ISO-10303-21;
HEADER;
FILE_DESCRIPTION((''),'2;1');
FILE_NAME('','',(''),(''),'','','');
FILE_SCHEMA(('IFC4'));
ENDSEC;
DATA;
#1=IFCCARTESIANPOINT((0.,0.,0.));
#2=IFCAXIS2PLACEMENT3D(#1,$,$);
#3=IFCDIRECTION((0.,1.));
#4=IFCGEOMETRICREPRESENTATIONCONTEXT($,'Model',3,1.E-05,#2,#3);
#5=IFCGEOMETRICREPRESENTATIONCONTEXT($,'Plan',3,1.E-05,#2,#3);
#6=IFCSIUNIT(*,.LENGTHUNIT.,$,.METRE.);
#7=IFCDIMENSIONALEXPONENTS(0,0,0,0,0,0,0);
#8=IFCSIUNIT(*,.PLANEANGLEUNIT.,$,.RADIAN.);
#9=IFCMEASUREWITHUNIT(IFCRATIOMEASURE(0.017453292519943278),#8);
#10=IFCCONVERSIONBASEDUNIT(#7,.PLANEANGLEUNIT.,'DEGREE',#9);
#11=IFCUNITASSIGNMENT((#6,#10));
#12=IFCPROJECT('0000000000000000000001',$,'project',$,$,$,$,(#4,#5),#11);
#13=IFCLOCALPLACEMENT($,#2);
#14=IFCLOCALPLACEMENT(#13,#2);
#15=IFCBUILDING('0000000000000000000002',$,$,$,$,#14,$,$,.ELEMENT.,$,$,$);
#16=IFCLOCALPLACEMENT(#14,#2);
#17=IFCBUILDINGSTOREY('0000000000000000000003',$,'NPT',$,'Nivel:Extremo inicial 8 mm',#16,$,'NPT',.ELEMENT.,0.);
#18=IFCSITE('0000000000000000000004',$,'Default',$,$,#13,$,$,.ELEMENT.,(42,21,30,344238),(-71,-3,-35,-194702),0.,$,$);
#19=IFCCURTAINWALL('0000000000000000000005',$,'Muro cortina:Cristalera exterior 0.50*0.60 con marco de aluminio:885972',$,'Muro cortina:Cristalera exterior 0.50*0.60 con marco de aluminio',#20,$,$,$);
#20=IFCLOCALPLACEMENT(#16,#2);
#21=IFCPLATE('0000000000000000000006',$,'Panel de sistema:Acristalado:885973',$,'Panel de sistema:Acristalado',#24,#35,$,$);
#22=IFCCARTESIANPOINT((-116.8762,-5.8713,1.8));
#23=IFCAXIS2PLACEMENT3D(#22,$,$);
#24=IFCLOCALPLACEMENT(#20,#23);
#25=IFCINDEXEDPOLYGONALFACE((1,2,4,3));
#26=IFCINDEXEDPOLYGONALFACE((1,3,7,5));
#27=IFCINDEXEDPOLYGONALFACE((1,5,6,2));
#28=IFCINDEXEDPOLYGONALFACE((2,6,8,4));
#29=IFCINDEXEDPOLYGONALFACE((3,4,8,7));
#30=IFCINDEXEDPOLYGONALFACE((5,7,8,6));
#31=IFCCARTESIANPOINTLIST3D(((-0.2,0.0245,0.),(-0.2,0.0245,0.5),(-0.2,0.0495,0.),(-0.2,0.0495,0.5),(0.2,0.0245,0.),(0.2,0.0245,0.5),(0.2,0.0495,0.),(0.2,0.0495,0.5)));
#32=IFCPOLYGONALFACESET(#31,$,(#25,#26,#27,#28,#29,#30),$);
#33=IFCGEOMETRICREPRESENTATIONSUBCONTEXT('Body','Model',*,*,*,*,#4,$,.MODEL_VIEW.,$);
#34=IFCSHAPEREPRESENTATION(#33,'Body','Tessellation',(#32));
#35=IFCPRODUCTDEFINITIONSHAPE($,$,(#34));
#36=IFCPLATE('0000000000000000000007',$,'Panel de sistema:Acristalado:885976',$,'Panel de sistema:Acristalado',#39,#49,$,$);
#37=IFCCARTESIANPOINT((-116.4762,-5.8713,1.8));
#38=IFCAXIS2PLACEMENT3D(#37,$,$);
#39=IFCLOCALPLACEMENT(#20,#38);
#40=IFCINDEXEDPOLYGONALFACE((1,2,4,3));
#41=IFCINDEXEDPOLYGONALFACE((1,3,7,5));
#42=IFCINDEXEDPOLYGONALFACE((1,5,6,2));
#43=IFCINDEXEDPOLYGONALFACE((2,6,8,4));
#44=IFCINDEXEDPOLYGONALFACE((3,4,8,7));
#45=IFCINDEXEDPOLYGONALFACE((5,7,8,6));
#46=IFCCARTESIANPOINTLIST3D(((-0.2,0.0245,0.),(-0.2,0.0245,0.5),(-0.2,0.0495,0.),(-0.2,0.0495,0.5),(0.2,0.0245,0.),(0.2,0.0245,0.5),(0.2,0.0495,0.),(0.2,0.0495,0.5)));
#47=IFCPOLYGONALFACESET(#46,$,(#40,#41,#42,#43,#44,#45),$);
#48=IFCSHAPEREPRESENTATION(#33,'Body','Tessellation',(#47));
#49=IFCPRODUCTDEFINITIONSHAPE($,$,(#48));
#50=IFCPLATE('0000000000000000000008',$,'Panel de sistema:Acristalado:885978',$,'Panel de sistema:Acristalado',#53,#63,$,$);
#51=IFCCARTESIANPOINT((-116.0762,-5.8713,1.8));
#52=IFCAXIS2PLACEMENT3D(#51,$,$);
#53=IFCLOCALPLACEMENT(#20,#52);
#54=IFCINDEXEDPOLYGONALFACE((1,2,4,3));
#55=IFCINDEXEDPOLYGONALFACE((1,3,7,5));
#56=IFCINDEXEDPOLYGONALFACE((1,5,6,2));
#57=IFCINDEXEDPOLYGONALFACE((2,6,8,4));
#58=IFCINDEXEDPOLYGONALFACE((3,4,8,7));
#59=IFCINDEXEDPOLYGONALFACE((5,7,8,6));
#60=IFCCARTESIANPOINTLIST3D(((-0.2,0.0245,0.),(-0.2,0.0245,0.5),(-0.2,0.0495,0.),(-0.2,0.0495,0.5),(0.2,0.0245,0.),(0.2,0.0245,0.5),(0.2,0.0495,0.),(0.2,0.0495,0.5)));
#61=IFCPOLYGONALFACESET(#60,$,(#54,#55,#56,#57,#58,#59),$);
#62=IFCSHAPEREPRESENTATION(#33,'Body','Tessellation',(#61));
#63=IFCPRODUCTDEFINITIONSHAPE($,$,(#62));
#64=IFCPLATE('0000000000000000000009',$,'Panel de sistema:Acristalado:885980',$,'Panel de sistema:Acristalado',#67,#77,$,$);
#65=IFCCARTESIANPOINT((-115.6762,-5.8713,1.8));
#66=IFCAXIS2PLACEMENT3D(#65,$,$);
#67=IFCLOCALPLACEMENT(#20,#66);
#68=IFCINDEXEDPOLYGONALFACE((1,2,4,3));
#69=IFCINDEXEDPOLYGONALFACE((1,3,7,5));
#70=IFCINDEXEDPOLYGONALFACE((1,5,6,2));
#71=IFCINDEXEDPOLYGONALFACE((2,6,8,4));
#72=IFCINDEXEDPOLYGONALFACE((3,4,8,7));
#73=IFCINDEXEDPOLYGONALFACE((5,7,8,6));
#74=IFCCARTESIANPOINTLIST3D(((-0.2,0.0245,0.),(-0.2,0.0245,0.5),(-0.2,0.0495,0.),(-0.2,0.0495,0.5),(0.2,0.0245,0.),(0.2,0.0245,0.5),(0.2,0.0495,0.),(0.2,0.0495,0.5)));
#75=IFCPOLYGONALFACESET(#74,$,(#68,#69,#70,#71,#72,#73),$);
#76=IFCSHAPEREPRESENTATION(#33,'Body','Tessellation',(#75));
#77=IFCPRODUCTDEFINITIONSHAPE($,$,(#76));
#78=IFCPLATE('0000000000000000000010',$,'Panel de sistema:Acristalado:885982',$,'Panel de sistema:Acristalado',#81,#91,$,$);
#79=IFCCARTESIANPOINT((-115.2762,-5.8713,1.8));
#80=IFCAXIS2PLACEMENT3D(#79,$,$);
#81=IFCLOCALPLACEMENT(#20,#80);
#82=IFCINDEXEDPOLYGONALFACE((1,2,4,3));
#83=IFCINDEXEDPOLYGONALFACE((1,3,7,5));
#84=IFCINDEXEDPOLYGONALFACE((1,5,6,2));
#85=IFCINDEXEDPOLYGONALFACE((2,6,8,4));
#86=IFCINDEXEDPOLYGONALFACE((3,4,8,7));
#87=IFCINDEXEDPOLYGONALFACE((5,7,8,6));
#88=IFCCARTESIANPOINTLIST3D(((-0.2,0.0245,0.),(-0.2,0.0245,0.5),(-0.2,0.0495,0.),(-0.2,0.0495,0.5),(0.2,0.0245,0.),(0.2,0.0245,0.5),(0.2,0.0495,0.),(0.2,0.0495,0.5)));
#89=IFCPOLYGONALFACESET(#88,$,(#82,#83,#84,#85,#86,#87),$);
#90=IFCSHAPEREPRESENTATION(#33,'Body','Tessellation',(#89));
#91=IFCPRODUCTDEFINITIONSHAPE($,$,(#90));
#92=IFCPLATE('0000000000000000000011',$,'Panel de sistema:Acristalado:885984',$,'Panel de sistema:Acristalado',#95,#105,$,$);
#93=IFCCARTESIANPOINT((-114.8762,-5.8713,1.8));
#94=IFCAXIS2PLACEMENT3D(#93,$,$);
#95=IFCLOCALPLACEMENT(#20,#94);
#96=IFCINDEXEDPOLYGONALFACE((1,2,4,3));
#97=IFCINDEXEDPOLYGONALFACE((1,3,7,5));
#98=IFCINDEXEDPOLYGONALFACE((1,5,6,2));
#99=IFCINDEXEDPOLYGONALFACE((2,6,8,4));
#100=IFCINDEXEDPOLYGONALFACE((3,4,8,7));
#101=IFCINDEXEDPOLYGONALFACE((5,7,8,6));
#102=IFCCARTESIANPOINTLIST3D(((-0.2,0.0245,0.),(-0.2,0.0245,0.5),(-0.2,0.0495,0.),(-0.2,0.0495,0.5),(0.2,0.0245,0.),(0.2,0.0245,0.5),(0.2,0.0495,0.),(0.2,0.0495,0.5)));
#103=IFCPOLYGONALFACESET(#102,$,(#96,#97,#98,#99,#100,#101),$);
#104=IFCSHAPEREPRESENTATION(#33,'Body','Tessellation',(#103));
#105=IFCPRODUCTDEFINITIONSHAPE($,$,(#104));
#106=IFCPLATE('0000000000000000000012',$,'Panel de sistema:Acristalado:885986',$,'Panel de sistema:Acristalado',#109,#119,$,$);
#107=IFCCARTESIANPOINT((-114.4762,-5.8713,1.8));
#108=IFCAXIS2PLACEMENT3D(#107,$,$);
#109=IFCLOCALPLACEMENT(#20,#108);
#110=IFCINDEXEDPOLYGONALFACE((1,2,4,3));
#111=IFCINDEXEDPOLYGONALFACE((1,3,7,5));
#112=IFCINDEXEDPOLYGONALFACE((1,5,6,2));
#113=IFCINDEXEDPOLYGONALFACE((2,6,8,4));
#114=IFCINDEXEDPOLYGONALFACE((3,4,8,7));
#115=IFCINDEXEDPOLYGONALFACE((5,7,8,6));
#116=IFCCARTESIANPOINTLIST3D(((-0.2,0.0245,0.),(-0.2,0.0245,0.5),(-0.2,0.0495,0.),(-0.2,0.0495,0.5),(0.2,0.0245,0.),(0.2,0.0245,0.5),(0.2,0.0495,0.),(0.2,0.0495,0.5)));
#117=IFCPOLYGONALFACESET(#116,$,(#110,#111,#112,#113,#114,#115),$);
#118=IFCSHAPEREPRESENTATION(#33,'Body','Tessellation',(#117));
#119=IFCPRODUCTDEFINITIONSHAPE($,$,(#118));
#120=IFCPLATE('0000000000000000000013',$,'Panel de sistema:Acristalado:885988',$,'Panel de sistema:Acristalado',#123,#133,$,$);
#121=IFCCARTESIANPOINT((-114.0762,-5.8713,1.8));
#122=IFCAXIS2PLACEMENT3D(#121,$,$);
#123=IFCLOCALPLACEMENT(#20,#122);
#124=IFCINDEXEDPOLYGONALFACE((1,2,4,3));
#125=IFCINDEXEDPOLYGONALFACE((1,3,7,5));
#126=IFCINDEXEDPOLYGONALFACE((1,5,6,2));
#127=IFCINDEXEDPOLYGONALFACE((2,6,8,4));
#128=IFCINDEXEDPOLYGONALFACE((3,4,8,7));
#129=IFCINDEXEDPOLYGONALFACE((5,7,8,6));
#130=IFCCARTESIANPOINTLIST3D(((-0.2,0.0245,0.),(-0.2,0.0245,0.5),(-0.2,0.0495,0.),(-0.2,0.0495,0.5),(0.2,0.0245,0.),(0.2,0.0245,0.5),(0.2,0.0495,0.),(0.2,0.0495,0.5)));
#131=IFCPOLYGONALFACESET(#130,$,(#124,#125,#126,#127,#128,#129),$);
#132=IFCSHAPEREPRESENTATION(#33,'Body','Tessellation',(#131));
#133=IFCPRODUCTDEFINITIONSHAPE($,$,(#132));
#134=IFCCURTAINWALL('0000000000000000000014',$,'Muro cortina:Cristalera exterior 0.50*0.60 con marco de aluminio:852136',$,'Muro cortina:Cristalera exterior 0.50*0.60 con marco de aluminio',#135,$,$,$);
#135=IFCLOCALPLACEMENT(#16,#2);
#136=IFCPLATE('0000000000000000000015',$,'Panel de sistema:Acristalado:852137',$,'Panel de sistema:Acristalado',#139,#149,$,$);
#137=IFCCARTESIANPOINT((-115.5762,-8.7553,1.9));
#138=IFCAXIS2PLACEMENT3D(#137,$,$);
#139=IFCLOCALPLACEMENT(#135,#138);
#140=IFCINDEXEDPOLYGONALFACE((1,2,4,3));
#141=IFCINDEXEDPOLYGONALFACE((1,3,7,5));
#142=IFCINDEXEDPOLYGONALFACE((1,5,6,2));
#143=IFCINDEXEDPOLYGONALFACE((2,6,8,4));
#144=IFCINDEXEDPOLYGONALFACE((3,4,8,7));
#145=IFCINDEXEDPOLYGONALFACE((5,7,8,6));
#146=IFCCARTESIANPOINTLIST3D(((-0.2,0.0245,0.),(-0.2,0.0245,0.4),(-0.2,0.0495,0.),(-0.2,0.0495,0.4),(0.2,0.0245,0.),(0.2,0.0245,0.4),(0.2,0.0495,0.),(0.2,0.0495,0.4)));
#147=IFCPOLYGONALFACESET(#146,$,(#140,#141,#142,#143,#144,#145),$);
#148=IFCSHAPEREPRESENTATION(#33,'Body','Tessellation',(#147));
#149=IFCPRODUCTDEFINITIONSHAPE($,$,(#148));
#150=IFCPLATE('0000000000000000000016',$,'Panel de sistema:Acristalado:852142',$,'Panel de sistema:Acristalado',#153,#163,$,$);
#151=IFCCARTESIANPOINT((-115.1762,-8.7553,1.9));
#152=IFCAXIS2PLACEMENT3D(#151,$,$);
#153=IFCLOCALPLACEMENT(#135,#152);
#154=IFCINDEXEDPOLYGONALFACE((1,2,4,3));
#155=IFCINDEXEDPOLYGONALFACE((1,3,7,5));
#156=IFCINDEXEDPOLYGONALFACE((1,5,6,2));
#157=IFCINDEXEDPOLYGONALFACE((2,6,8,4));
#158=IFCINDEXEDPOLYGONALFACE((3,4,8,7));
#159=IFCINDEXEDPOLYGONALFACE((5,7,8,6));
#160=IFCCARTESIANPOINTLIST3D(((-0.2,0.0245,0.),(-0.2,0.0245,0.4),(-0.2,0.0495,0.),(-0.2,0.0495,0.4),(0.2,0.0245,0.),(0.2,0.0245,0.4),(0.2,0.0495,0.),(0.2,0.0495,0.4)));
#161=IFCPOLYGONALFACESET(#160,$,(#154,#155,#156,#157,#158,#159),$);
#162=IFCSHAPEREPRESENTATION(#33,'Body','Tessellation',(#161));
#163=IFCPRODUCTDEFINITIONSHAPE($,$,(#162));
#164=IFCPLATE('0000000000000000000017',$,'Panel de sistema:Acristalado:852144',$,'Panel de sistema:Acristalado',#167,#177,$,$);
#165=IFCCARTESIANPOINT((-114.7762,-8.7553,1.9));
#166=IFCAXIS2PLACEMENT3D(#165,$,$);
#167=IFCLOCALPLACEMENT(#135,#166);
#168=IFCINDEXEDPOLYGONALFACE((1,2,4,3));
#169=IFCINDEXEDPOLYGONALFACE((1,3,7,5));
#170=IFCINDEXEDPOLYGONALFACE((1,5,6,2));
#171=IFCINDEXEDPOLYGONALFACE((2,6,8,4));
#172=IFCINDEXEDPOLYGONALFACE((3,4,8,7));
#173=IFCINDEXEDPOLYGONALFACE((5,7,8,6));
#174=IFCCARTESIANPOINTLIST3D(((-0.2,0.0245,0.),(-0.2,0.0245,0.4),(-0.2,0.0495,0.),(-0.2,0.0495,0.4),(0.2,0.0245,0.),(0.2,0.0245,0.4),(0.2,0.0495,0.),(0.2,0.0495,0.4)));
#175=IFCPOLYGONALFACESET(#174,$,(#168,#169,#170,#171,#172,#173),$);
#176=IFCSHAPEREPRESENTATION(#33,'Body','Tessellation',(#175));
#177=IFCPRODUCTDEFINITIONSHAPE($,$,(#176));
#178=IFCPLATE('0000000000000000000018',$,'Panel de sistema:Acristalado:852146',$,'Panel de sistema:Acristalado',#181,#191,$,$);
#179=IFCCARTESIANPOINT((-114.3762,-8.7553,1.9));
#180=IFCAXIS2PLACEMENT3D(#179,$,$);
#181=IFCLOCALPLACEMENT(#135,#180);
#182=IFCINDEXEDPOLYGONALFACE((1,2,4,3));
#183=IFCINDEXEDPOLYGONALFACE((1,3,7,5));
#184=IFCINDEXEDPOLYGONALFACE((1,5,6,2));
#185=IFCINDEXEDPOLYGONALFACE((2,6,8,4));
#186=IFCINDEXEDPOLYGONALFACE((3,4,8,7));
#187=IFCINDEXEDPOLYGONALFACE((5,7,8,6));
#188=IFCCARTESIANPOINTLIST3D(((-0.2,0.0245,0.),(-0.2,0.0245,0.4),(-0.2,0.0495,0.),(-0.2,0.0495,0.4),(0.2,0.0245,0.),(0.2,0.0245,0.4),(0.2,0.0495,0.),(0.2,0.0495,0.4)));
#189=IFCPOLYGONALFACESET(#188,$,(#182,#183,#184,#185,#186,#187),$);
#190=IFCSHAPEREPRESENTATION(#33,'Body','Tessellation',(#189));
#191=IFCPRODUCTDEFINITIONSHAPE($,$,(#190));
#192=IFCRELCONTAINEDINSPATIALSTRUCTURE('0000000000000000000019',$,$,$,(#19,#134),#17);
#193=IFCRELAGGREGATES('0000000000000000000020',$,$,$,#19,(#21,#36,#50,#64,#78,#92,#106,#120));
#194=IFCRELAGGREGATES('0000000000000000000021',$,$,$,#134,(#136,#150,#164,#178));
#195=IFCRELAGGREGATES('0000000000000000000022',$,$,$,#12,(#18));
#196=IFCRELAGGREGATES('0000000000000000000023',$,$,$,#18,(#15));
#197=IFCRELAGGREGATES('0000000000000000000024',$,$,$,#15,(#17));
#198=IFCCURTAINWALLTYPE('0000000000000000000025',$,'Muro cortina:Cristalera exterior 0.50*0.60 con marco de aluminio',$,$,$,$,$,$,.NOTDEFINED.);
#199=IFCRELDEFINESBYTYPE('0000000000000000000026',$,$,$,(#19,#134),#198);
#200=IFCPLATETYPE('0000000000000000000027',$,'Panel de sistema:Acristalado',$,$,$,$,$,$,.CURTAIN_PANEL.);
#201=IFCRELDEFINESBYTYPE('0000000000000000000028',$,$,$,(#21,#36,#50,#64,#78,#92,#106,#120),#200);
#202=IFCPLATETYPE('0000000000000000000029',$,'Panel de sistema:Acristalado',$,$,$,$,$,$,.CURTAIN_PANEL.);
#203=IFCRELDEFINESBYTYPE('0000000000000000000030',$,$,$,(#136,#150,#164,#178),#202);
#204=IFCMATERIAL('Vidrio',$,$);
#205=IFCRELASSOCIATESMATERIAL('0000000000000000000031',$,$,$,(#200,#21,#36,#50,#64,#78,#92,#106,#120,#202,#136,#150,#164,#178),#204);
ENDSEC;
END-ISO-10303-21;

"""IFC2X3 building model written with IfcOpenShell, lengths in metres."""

from ifc_helpers import new_model, entity, si_unit, converted_unit, direction, frame, origin, origin_2d_with_axis, place, context, subcontext, project, spatial, rectangle, extrude, source, transform, mapped, material, type_object, type_shapes, element, aggregate, save


model = new_model("IFC2X3")

# Units and contexts
model_context = context("Model", 3, precision=1e-05, world=origin(), true_north=direction((0.0, 1.0)))
plan_context = context("Plan", 3, precision=1e-05, world=origin(), true_north=direction((0.0, 1.0)))
body_context = subcontext(model_context, "Body", "Model", "MODEL_VIEW")
ifc_project = project(units=[si_unit("LENGTHUNIT", "METRE"), converted_unit("PLANEANGLEUNIT", "DEGREE", entity("IfcRatioMeasure", 0.017453292519943278), si_unit("PLANEANGLEUNIT", "RADIAN"), dimensions=[0, 0, 0, 0, 0, 0, 0])], contexts=[model_context, plan_context])

# Site, building, storey
site_placement = place(None, origin())
site = spatial("IfcSite", under=ifc_project, at=site_placement, Name="Default", CompositionType="ELEMENT", RefLatitude=(42, 21, 30, 344238), RefLongitude=(-71, -3, -35, -194702), RefElevation=0.0)
building_placement = place(site_placement, origin())
building = spatial("IfcBuilding", under=site, at=building_placement, CompositionType="ELEMENT")
storey_placement = place(building_placement, origin())
storey = spatial("IfcBuildingStorey", under=building, at=storey_placement, Name="NPT", ObjectType="Nivel:Extremo inicial 8 mm", LongName="NPT", CompositionType="ELEMENT", Elevation=0.0)

# Curtain walls, plates
curtain_wall_type = type_object("IfcCurtainWallType", Name="Muro cortina:Cristalera exterior 0.50*0.60 con marco de aluminio", PredefinedType="NOTDEFINED")
curtain_wall_1_placement = place(storey_placement, origin())
curtain_wall_1 = element("IfcCurtainWall", 1, at=curtain_wall_1_placement, inside=storey, type_object=curtain_wall_type, Name="Muro cortina:Cristalera exterior 0.50*0.60 con marco de aluminio:885972", ObjectType="Muro cortina:Cristalera exterior 0.50*0.60 con marco de aluminio")
ifc_material_1 = material(Name="Vidrio")
plate_type_1 = type_object("IfcPlateType", Name="Panel de sistema:Acristalado", PredefinedType="CURTAIN_PANEL", material=ifc_material_1)
shared_shape_1 = source(origin(), body_context, "Body", "SweptSolid", [
    extrude(rectangle(XDim=0.025, YDim=0.4, at=origin_2d_with_axis()), frame((0.0, 0.037, 0.0), z_axis=(0.0, 0.0, 1.0), x_axis=(0.0, 1.0, 0.0)), (0.0, 0.0, 1.0), 0.5),
])
type_shapes(plate_type_1, [shared_shape_1])
plate_1_placement = place(curtain_wall_1_placement, frame((-116.8762, -5.8713, 1.8)))
plate_1 = element("IfcPlate", 2, at=plate_1_placement, type_object=plate_type_1, material=ifc_material_1, Name="Panel de sistema:Acristalado:885973", ObjectType="Panel de sistema:Acristalado", context=body_context, shape_type="MappedRepresentation", body=[
    mapped(shared_shape_1, transform((0.0, 0.0, 0.0), scale=1.0)),
])
plate_2_placement = place(curtain_wall_1_placement, frame((-116.4762, -5.8713, 1.8)))
plate_2 = element("IfcPlate", 3, at=plate_2_placement, type_object=plate_type_1, material=ifc_material_1, Name="Panel de sistema:Acristalado:885976", ObjectType="Panel de sistema:Acristalado", context=body_context, shape_type="MappedRepresentation", body=[
    mapped(shared_shape_1, transform((0.0, 0.0, 0.0), scale=1.0)),
])
plate_3_placement = place(curtain_wall_1_placement, frame((-116.0762, -5.8713, 1.8)))
plate_3 = element("IfcPlate", 4, at=plate_3_placement, type_object=plate_type_1, material=ifc_material_1, Name="Panel de sistema:Acristalado:885978", ObjectType="Panel de sistema:Acristalado", context=body_context, shape_type="MappedRepresentation", body=[
    mapped(shared_shape_1, transform((0.0, 0.0, 0.0), scale=1.0)),
])
plate_4_placement = place(curtain_wall_1_placement, frame((-115.6762, -5.8713, 1.8)))
plate_4 = element("IfcPlate", 5, at=plate_4_placement, type_object=plate_type_1, material=ifc_material_1, Name="Panel de sistema:Acristalado:885980", ObjectType="Panel de sistema:Acristalado", context=body_context, shape_type="MappedRepresentation", body=[
    mapped(shared_shape_1, transform((0.0, 0.0, 0.0), scale=1.0)),
])
plate_5_placement = place(curtain_wall_1_placement, frame((-115.2762, -5.8713, 1.8)))
plate_5 = element("IfcPlate", 6, at=plate_5_placement, type_object=plate_type_1, material=ifc_material_1, Name="Panel de sistema:Acristalado:885982", ObjectType="Panel de sistema:Acristalado", context=body_context, shape_type="MappedRepresentation", body=[
    mapped(shared_shape_1, transform((0.0, 0.0, 0.0), scale=1.0)),
])
plate_6_placement = place(curtain_wall_1_placement, frame((-114.8762, -5.8713, 1.8)))
plate_6 = element("IfcPlate", 7, at=plate_6_placement, type_object=plate_type_1, material=ifc_material_1, Name="Panel de sistema:Acristalado:885984", ObjectType="Panel de sistema:Acristalado", context=body_context, shape_type="MappedRepresentation", body=[
    mapped(shared_shape_1, transform((0.0, 0.0, 0.0), scale=1.0)),
])
plate_7_placement = place(curtain_wall_1_placement, frame((-114.4762, -5.8713, 1.8)))
plate_7 = element("IfcPlate", 8, at=plate_7_placement, type_object=plate_type_1, material=ifc_material_1, Name="Panel de sistema:Acristalado:885986", ObjectType="Panel de sistema:Acristalado", context=body_context, shape_type="MappedRepresentation", body=[
    mapped(shared_shape_1, transform((0.0, 0.0, 0.0), scale=1.0)),
])
plate_8_placement = place(curtain_wall_1_placement, frame((-114.0762, -5.8713, 1.8)))
plate_8 = element("IfcPlate", 9, at=plate_8_placement, type_object=plate_type_1, material=ifc_material_1, Name="Panel de sistema:Acristalado:885988", ObjectType="Panel de sistema:Acristalado", context=body_context, shape_type="MappedRepresentation", body=[
    mapped(shared_shape_1, transform((0.0, 0.0, 0.0), scale=1.0)),
])
aggregate(curtain_wall_1, [plate_1, plate_2, plate_3, plate_4, plate_5, plate_6, plate_7, plate_8])
curtain_wall_2_placement = place(storey_placement, origin())
curtain_wall_2 = element("IfcCurtainWall", 10, at=curtain_wall_2_placement, inside=storey, type_object=curtain_wall_type, Name="Muro cortina:Cristalera exterior 0.50*0.60 con marco de aluminio:852136", ObjectType="Muro cortina:Cristalera exterior 0.50*0.60 con marco de aluminio")
plate_type_2 = type_object("IfcPlateType", Name="Panel de sistema:Acristalado", PredefinedType="CURTAIN_PANEL", material=ifc_material_1)
shared_shape_2 = source(origin(), body_context, "Body", "SweptSolid", [
    extrude(rectangle(XDim=0.025, YDim=0.4, at=origin_2d_with_axis()), frame((0.0, 0.037, 0.0), z_axis=(0.0, 0.0, 1.0), x_axis=(0.0, 1.0, 0.0)), (0.0, 0.0, 1.0), 0.4),
])
type_shapes(plate_type_2, [shared_shape_2])
plate_9_placement = place(curtain_wall_2_placement, frame((-115.5762, -8.7553, 1.9)))
plate_9 = element("IfcPlate", 11, at=plate_9_placement, type_object=plate_type_2, material=ifc_material_1, Name="Panel de sistema:Acristalado:852137", ObjectType="Panel de sistema:Acristalado", context=body_context, shape_type="MappedRepresentation", body=[
    mapped(shared_shape_2, transform((0.0, 0.0, 0.0), scale=1.0)),
])
plate_10_placement = place(curtain_wall_2_placement, frame((-115.1762, -8.7553, 1.9)))
plate_10 = element("IfcPlate", 12, at=plate_10_placement, type_object=plate_type_2, material=ifc_material_1, Name="Panel de sistema:Acristalado:852142", ObjectType="Panel de sistema:Acristalado", context=body_context, shape_type="MappedRepresentation", body=[
    mapped(shared_shape_2, transform((0.0, 0.0, 0.0), scale=1.0)),
])
plate_11_placement = place(curtain_wall_2_placement, frame((-114.7762, -8.7553, 1.9)))
plate_11 = element("IfcPlate", 13, at=plate_11_placement, type_object=plate_type_2, material=ifc_material_1, Name="Panel de sistema:Acristalado:852144", ObjectType="Panel de sistema:Acristalado", context=body_context, shape_type="MappedRepresentation", body=[
    mapped(shared_shape_2, transform((0.0, 0.0, 0.0), scale=1.0)),
])
plate_12_placement = place(curtain_wall_2_placement, frame((-114.3762, -8.7553, 1.9)))
plate_12 = element("IfcPlate", 14, at=plate_12_placement, type_object=plate_type_2, material=ifc_material_1, Name="Panel de sistema:Acristalado:852146", ObjectType="Panel de sistema:Acristalado", context=body_context, shape_type="MappedRepresentation", body=[
    mapped(shared_shape_2, transform((0.0, 0.0, 0.0), scale=1.0)),
])
aggregate(curtain_wall_2, [plate_9, plate_10, plate_11, plate_12])

save(model, "model.ifc")
